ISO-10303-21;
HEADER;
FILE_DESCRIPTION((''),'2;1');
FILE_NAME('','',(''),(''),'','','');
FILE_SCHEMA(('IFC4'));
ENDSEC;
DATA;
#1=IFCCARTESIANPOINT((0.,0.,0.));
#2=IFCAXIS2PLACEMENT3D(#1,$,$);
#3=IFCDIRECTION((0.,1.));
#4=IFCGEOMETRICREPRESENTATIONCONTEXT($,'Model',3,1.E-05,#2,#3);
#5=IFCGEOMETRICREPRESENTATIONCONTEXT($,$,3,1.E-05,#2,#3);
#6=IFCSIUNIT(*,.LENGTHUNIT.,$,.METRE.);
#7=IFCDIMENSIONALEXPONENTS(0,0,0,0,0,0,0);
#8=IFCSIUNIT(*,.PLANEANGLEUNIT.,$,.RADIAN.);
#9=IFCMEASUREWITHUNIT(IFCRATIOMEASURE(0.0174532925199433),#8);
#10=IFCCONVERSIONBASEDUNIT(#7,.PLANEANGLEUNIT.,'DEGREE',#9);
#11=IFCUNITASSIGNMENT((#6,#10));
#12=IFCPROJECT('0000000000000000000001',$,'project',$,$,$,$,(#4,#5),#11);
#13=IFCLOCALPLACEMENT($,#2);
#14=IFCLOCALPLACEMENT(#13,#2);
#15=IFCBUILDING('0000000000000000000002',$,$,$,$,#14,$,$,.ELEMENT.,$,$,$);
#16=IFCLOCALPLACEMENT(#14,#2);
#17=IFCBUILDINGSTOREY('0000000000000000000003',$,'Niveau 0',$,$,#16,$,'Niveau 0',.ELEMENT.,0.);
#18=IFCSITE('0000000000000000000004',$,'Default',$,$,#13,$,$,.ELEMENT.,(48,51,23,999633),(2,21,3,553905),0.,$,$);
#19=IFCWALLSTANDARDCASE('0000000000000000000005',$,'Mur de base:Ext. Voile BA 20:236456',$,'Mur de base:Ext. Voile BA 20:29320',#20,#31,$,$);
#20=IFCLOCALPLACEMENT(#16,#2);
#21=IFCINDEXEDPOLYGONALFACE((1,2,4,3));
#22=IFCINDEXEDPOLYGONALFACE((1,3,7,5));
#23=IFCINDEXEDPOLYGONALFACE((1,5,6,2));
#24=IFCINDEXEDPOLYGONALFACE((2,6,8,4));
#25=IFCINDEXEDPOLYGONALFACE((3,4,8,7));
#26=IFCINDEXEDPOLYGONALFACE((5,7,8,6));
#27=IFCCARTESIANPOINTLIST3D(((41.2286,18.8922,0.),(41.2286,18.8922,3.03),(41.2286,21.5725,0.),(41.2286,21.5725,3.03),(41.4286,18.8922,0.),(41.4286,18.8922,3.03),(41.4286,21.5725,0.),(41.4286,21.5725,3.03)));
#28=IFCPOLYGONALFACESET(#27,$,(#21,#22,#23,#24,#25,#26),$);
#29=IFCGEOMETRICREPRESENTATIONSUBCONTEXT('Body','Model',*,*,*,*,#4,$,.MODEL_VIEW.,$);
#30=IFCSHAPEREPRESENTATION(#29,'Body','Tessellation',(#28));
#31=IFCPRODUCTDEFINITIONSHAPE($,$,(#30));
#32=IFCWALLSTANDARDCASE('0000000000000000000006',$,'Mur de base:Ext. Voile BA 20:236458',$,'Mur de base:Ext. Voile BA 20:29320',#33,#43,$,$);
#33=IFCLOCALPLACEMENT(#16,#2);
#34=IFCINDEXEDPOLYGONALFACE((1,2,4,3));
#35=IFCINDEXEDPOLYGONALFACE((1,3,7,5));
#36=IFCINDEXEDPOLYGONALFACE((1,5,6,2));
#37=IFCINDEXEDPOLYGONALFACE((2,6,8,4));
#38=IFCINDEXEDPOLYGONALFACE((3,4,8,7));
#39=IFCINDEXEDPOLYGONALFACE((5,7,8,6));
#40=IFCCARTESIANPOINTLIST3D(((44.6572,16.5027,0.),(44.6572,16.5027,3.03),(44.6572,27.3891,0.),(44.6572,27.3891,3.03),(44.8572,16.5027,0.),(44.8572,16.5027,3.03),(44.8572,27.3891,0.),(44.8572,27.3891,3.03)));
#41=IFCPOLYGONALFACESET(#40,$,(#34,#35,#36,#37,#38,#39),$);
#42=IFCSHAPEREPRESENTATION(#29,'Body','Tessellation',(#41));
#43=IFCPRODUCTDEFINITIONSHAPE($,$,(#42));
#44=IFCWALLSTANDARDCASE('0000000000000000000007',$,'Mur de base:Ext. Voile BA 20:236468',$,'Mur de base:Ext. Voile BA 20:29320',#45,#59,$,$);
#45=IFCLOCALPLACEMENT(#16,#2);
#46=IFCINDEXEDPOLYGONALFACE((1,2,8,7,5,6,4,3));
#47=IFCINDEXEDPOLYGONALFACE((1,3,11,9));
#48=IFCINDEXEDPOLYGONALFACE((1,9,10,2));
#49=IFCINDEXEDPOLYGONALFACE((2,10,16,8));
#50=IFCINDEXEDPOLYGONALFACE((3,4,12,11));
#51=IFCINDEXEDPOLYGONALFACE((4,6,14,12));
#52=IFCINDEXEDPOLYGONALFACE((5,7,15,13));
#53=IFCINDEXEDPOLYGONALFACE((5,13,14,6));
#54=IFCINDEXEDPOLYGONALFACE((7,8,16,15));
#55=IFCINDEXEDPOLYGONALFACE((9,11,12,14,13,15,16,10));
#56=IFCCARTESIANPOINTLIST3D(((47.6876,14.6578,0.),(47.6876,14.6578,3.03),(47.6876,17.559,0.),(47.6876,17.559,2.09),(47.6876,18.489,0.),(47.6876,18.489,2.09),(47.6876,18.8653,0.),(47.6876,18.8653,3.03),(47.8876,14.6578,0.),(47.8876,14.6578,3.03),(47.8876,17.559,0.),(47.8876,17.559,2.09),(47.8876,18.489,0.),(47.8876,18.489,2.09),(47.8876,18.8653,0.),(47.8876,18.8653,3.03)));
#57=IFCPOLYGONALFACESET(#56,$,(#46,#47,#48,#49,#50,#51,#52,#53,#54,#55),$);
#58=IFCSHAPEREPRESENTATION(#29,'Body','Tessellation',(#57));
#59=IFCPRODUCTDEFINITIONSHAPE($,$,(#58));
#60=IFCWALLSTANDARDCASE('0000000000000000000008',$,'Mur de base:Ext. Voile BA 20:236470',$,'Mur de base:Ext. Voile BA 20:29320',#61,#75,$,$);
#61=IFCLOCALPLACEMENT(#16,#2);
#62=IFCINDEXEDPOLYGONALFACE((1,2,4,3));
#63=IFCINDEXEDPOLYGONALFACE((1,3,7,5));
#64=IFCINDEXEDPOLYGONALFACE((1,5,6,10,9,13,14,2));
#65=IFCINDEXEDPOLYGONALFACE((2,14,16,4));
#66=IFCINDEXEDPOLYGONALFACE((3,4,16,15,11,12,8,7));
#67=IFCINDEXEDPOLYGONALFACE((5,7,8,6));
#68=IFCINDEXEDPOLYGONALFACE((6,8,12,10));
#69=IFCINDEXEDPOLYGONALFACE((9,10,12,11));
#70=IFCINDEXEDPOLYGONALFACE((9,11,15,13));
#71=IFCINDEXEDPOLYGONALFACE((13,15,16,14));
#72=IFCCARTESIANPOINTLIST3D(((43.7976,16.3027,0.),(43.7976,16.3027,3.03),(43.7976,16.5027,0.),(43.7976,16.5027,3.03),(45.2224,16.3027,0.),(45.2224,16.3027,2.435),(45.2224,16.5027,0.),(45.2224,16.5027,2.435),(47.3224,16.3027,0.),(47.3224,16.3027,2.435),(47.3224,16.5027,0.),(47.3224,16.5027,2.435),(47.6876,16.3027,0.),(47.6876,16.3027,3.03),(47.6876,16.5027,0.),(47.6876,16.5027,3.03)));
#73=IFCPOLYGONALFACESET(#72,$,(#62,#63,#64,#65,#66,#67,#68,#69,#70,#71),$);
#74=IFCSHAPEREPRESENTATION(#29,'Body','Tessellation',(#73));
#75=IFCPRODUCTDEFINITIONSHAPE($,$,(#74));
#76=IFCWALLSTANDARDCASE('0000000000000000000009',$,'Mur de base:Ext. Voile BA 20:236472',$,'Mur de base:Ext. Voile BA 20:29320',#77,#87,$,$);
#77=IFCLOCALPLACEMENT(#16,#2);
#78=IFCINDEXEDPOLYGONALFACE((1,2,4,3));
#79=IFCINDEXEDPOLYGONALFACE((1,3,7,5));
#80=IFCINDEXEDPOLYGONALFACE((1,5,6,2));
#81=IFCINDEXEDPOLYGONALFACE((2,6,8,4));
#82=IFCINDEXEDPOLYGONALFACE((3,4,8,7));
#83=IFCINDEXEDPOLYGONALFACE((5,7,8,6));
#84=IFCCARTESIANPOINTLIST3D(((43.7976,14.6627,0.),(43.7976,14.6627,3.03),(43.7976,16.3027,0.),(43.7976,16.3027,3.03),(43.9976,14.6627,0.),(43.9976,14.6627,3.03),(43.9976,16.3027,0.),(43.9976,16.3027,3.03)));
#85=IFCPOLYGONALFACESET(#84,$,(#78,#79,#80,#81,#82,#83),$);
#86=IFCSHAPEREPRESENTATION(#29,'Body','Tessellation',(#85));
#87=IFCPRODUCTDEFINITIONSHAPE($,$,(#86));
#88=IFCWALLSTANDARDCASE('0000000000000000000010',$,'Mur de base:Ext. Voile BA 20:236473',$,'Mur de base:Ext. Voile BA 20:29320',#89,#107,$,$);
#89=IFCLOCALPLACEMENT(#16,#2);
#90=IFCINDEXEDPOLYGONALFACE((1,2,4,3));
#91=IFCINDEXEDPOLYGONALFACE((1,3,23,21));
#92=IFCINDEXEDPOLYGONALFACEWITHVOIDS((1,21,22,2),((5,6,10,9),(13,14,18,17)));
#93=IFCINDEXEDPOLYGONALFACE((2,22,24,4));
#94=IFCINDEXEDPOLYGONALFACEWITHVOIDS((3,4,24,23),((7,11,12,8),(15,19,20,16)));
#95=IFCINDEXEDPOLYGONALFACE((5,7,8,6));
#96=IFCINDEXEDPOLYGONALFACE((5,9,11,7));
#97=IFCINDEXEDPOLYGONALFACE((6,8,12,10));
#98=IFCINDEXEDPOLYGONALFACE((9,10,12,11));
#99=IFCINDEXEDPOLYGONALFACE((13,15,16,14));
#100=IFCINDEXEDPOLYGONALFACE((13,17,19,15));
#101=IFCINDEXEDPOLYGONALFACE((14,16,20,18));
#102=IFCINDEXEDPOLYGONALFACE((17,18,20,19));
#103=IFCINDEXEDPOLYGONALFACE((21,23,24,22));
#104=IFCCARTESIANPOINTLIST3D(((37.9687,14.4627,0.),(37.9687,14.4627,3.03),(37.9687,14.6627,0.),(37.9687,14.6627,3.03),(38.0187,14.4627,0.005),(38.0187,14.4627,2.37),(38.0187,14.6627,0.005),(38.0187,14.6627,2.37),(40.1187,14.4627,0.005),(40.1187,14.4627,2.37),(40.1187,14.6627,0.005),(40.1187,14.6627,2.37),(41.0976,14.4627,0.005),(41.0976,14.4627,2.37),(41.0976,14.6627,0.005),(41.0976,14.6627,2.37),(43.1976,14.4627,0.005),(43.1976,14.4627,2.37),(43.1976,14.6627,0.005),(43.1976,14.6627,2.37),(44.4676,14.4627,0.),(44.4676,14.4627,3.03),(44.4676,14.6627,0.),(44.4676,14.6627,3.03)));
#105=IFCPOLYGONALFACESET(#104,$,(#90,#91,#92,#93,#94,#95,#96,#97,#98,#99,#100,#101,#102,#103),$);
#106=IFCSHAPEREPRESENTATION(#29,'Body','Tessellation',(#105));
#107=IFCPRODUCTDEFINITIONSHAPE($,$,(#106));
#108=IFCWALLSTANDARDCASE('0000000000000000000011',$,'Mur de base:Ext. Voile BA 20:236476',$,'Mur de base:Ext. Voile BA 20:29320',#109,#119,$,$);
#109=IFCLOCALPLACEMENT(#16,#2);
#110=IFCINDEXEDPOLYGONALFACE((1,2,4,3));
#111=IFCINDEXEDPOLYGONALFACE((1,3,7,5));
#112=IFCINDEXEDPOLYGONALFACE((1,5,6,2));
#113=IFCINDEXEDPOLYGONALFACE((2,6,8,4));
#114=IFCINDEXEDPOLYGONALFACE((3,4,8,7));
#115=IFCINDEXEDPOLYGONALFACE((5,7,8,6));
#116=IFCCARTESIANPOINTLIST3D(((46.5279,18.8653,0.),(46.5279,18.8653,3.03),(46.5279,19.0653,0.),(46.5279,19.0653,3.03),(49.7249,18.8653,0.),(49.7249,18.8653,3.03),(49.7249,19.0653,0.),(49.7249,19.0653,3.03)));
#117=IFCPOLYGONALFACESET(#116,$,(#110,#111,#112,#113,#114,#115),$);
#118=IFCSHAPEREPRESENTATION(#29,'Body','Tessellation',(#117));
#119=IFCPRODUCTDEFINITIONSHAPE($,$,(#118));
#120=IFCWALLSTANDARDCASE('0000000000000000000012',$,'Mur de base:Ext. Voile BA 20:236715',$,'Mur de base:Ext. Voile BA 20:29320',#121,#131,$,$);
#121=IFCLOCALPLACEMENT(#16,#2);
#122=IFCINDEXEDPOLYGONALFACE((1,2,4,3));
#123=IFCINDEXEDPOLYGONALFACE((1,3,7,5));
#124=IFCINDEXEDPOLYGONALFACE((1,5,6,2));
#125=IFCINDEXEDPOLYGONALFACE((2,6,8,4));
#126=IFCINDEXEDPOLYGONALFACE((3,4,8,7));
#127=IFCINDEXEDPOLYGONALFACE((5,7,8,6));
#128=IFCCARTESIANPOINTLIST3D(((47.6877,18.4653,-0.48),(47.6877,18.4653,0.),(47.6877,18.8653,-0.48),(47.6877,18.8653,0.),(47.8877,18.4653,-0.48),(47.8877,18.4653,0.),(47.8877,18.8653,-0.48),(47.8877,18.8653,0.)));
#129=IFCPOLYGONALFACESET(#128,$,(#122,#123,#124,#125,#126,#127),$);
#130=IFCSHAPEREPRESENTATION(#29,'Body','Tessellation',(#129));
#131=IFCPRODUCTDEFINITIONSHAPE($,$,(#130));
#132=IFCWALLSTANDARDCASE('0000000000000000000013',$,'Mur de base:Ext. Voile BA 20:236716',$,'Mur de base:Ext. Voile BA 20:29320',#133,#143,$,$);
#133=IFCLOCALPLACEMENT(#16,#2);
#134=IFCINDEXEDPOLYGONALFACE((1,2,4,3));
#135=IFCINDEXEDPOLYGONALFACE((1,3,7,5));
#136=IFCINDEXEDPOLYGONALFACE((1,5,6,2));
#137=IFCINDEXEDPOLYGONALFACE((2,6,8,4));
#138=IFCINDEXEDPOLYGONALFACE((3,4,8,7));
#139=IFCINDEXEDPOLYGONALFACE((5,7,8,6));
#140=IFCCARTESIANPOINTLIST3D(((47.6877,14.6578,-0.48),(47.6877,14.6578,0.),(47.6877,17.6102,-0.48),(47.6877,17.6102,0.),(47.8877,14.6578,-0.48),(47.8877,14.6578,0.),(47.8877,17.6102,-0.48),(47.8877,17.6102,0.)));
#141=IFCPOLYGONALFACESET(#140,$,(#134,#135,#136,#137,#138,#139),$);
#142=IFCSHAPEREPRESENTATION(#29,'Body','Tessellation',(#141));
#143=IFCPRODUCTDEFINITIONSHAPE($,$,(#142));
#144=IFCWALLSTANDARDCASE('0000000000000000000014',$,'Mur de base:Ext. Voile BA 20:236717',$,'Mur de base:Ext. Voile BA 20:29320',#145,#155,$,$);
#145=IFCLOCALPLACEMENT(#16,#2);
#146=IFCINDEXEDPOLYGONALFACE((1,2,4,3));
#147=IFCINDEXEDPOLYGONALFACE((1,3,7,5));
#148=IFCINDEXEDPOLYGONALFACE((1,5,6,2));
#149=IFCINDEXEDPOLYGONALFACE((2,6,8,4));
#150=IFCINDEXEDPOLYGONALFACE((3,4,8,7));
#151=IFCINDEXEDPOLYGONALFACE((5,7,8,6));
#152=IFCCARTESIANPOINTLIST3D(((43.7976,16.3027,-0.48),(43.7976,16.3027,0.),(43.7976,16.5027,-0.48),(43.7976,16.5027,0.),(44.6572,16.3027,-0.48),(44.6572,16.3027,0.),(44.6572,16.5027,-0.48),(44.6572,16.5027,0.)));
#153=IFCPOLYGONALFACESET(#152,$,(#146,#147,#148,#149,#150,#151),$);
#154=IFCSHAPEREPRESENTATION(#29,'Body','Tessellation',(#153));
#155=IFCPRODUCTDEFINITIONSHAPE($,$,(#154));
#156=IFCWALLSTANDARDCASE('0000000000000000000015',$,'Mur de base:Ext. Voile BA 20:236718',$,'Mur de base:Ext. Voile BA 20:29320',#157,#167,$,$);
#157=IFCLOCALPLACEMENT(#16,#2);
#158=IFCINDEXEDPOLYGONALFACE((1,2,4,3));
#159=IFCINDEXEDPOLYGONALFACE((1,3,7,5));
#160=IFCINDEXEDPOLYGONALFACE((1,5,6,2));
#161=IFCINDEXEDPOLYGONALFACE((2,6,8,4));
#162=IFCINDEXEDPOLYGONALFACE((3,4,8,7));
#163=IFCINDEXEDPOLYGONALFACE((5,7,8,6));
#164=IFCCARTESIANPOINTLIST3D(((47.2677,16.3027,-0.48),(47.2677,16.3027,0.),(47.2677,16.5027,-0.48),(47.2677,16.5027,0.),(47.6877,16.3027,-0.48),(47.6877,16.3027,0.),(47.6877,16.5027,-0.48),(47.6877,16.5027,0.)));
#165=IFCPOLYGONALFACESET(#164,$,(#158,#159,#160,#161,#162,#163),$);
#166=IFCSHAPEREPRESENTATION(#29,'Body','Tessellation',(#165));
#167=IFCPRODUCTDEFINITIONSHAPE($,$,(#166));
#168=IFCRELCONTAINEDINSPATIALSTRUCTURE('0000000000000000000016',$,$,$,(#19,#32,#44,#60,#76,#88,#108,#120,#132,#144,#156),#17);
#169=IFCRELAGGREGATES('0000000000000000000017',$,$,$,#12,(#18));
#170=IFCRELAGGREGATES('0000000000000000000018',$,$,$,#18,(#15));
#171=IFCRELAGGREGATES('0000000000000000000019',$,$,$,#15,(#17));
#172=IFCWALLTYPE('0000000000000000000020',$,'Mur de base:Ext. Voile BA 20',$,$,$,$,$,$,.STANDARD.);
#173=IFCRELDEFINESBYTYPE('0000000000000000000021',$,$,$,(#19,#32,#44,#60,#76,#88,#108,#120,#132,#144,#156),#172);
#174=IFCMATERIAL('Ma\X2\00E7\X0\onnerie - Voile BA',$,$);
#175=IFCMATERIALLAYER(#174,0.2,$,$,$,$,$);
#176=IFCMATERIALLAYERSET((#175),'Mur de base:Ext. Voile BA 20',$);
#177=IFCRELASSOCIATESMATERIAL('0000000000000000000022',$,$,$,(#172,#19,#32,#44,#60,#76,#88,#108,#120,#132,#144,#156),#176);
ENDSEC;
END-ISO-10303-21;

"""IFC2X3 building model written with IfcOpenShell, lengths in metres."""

from ifc_helpers import new_model, entity, si_unit, converted_unit, direction, frame, frame_2d, origin, origin_2d_with_axis, place, context, subcontext, project, spatial, rectangle, extrude, material, layer, layer_set, layer_usage, type_object, element, save


model = new_model("IFC2X3")

# Units and contexts
model_context = context("Model", 3, precision=1e-05, world=origin(), true_north=direction((0.0, 1.0)))
context_of_model = context(None, 3, precision=1e-05, world=origin(), true_north=direction((0.0, 1.0)))
body_context = subcontext(model_context, "Body", "Model", "MODEL_VIEW")
ifc_project = project(units=[si_unit("LENGTHUNIT", "METRE"), converted_unit("PLANEANGLEUNIT", "DEGREE", entity("IfcRatioMeasure", 0.0174532925199433), si_unit("PLANEANGLEUNIT", "RADIAN"), dimensions=[0, 0, 0, 0, 0, 0, 0])], contexts=[model_context, context_of_model])

# Site, building, storey
site_placement = place(None, origin())
site = spatial("IfcSite", under=ifc_project, at=site_placement, Name="Default", CompositionType="ELEMENT", RefLatitude=(48, 51, 23, 999633), RefLongitude=(2, 21, 3, 553905), RefElevation=0.0)
building_placement = place(site_placement, origin())
building = spatial("IfcBuilding", under=site, at=building_placement, CompositionType="ELEMENT")
storey_placement = place(building_placement, origin())
storey = spatial("IfcBuildingStorey", under=building, at=storey_placement, Name="Niveau 0", LongName="Niveau 0", CompositionType="ELEMENT", Elevation=0.0)

# Walls
ifc_material = material(Name="Maçonnerie - Voile BA")
ifc_layer_1 = layer(ifc_material, 0.2)
ifc_layer_set_1 = layer_set([ifc_layer_1], Name="Mur de base:Ext. Voile BA 20")
ifc_layer_usage_1 = layer_usage(ifc_layer_set_1, "AXIS2", "NEGATIVE", 0.1)
wall_type_1 = type_object("IfcWallType", Name="Mur de base:Ext. Voile BA 20", PredefinedType="STANDARD", material=ifc_layer_set_1)
wall_1_placement = place(storey_placement, frame((41.3286, 18.8922, 0.0), z_axis=(0.0, 0.0, 1.0), x_axis=(0.0, 1.0, 0.0)))
element("IfcWallStandardCase", 1, at=wall_1_placement, inside=storey, type_object=wall_type_1, material=ifc_layer_usage_1, Name="Mur de base:Ext. Voile BA 20:236456", ObjectType="Mur de base:Ext. Voile BA 20:29320", context=body_context, shape_type="SweptSolid", body=[
    extrude(rectangle(XDim=2.6803, YDim=0.2, at=frame_2d((1.3402, 0.0), x_axis=(-1.0, 0.0))), origin(), (0.0, 0.0, 1.0), 3.03),
])
ifc_layer_usage_2 = layer_usage(ifc_layer_set_1, "AXIS2", "NEGATIVE", 0.1)
wall_2_placement = place(storey_placement, frame((44.7572, 16.5027, 0.0), z_axis=(0.0, 0.0, 1.0), x_axis=(0.0, 1.0, 0.0)))
element("IfcWallStandardCase", 2, at=wall_2_placement, inside=storey, type_object=wall_type_1, material=ifc_layer_usage_2, Name="Mur de base:Ext. Voile BA 20:236458", ObjectType="Mur de base:Ext. Voile BA 20:29320", context=body_context, shape_type="SweptSolid", body=[
    extrude(rectangle(XDim=10.8864, YDim=0.2, at=frame_2d((5.4432, 0.0), x_axis=(-1.0, 0.0))), origin(), (0.0, 0.0, 1.0), 3.03),
])

# Walls, openings
ifc_layer_usage_3 = layer_usage(ifc_layer_set_1, "AXIS2", "NEGATIVE", 0.1)
wall_3_placement = place(storey_placement, frame((47.7876, 14.6578, 0.0), z_axis=(0.0, 0.0, 1.0), x_axis=(0.0, 1.0, 0.0)))
wall_3 = element("IfcWallStandardCase", 3, at=wall_3_placement, inside=storey, type_object=wall_type_1, material=ifc_layer_usage_3, Name="Mur de base:Ext. Voile BA 20:236468", ObjectType="Mur de base:Ext. Voile BA 20:29320", context=body_context, shape_type="SweptSolid", body=[
    extrude(rectangle(XDim=4.2075, YDim=0.2, at=frame_2d((2.1037, 0.0), x_axis=(-1.0, 0.0))), origin(), (0.0, 0.0, 1.0), 3.03),
])
opening_1_placement = place(wall_3_placement, origin())
element("IfcOpeningElement", 4, at=opening_1_placement, cuts=wall_3, ObjectType="Opening", context=body_context, shape_type="SweptSolid", body=[
    extrude(rectangle(XDim=2.09, YDim=0.93, at=origin_2d_with_axis()), frame((3.3661, -0.1, 1.045), z_axis=(0.0, 1.0, 0.0), x_axis=(0.0, 0.0, -1.0)), (0.0, 0.0, 1.0), 0.2),
])
ifc_layer_usage_4 = layer_usage(ifc_layer_set_1, "AXIS2", "NEGATIVE", 0.1)
wall_4_placement = place(storey_placement, frame((47.6876, 16.4027, 0.0), z_axis=(0.0, 0.0, 1.0), x_axis=(-1.0, 0.0, 0.0)))
wall_4 = element("IfcWallStandardCase", 5, at=wall_4_placement, inside=storey, type_object=wall_type_1, material=ifc_layer_usage_4, Name="Mur de base:Ext. Voile BA 20:236470", ObjectType="Mur de base:Ext. Voile BA 20:29320", context=body_context, shape_type="SweptSolid", body=[
    extrude(rectangle(XDim=3.89, YDim=0.2, at=frame_2d((1.945, 0.0), x_axis=(-1.0, 0.0))), origin(), (0.0, 0.0, 1.0), 3.03),
])
opening_2_placement = place(wall_4_placement, origin())
element("IfcOpeningElement", 6, at=opening_2_placement, cuts=wall_4, ObjectType="Opening", context=body_context, shape_type="SweptSolid", body=[
    extrude(rectangle(XDim=2.465, YDim=2.1, at=frame_2d((0.0, 0.0), x_axis=(1.0, 0.0))), frame((1.4152, -0.1, 1.2025), z_axis=(0.0, 1.0, 0.0), x_axis=(0.0, 0.0, -1.0)), (0.0, 0.0, 1.0), 0.2),
])

# Wall
ifc_layer_usage_5 = layer_usage(ifc_layer_set_1, "AXIS2", "NEGATIVE", 0.1)
wall_5_placement = place(storey_placement, frame((43.8976, 16.3027, 0.0), z_axis=(0.0, 0.0, 1.0), x_axis=(0.0, -1.0, 0.0)))
element("IfcWallStandardCase", 7, at=wall_5_placement, inside=storey, type_object=wall_type_1, material=ifc_layer_usage_5, Name="Mur de base:Ext. Voile BA 20:236472", ObjectType="Mur de base:Ext. Voile BA 20:29320", context=body_context, shape_type="SweptSolid", body=[
    extrude(rectangle(XDim=1.64, YDim=0.2, at=frame_2d((0.82, 0.0), x_axis=(-1.0, 0.0))), origin(), (0.0, 0.0, 1.0), 3.03),
])

# Wall, openings
ifc_layer_usage_6 = layer_usage(ifc_layer_set_1, "AXIS2", "NEGATIVE", 0.1)
wall_6_placement = place(storey_placement, frame((44.4676, 14.5627, 0.0), z_axis=(0.0, 0.0, 1.0), x_axis=(-1.0, 0.0, 0.0)))
wall_6 = element("IfcWallStandardCase", 8, at=wall_6_placement, inside=storey, type_object=wall_type_1, material=ifc_layer_usage_6, Name="Mur de base:Ext. Voile BA 20:236473", ObjectType="Mur de base:Ext. Voile BA 20:29320", context=body_context, shape_type="SweptSolid", body=[
    extrude(rectangle(XDim=6.4988, YDim=0.2, at=frame_2d((3.2494, 0.0), x_axis=(-1.0, 0.0))), origin(), (0.0, 0.0, 1.0), 3.03),
])
opening_3_placement = place(wall_6_placement, origin())
element("IfcOpeningElement", 9, at=opening_3_placement, cuts=wall_6, ObjectType="Opening", context=body_context, shape_type="SweptSolid", body=[
    extrude(rectangle(XDim=2.365, YDim=2.1, at=frame_2d((0.0, 0.0), x_axis=(1.0, 0.0))), frame((5.3988, -0.1, 1.1875), z_axis=(0.0, 1.0, 0.0), x_axis=(0.0, 0.0, -1.0)), (0.0, 0.0, 1.0), 0.2),
])
opening_4_placement = place(wall_6_placement, origin())
element("IfcOpeningElement", 10, at=opening_4_placement, cuts=wall_6, ObjectType="Opening", context=body_context, shape_type="SweptSolid", body=[
    extrude(rectangle(XDim=2.365, YDim=2.1, at=origin_2d_with_axis()), frame((2.32, -0.1, 1.1875), z_axis=(0.0, 1.0, 0.0), x_axis=(0.0, 0.0, -1.0)), (0.0, 0.0, 1.0), 0.2),
])

# Walls
ifc_layer_usage_7 = layer_usage(ifc_layer_set_1, "AXIS2", "NEGATIVE", 0.1)
wall_7_placement = place(storey_placement, frame((46.5279, 18.9653, 0.0)))
element("IfcWallStandardCase", 11, at=wall_7_placement, inside=storey, type_object=wall_type_1, material=ifc_layer_usage_7, Name="Mur de base:Ext. Voile BA 20:236476", ObjectType="Mur de base:Ext. Voile BA 20:29320", context=body_context, shape_type="SweptSolid", body=[
    extrude(rectangle(XDim=3.197, YDim=0.2, at=frame_2d((1.5985, 0.0), x_axis=(-1.0, 0.0))), origin(), (0.0, 0.0, 1.0), 3.03),
])
ifc_layer_usage_8 = layer_usage(ifc_layer_set_1, "AXIS2", "NEGATIVE", 0.1)
wall_8_placement = place(storey_placement, frame((47.7877, 18.8653, -0.48), z_axis=(0.0, 0.0, 1.0), x_axis=(0.0, -1.0, 0.0)))
element("IfcWallStandardCase", 12, at=wall_8_placement, inside=storey, type_object=wall_type_1, material=ifc_layer_usage_8, Name="Mur de base:Ext. Voile BA 20:236715", ObjectType="Mur de base:Ext. Voile BA 20:29320", context=body_context, shape_type="SweptSolid", body=[
    extrude(rectangle(XDim=0.4, YDim=0.2, at=frame_2d((0.2, 0.0), x_axis=(-1.0, 0.0))), origin(), (0.0, 0.0, 1.0), 0.48),
])
ifc_layer_usage_9 = layer_usage(ifc_layer_set_1, "AXIS2", "NEGATIVE", 0.1)
wall_9_placement = place(storey_placement, frame((47.7877, 17.6102, -0.48), z_axis=(0.0, 0.0, 1.0), x_axis=(0.0, -1.0, 0.0)))
element("IfcWallStandardCase", 13, at=wall_9_placement, inside=storey, type_object=wall_type_1, material=ifc_layer_usage_9, Name="Mur de base:Ext. Voile BA 20:236716", ObjectType="Mur de base:Ext. Voile BA 20:29320", context=body_context, shape_type="SweptSolid", body=[
    extrude(rectangle(XDim=2.9523, YDim=0.2, at=frame_2d((1.4762, 0.0), x_axis=(-1.0, 0.0))), origin(), (0.0, 0.0, 1.0), 0.48),
])
ifc_layer_usage_10 = layer_usage(ifc_layer_set_1, "AXIS2", "NEGATIVE", 0.1)
wall_10_placement = place(storey_placement, frame((43.7976, 16.4027, -0.48)))
element("IfcWallStandardCase", 14, at=wall_10_placement, inside=storey, type_object=wall_type_1, material=ifc_layer_usage_10, Name="Mur de base:Ext. Voile BA 20:236717", ObjectType="Mur de base:Ext. Voile BA 20:29320", context=body_context, shape_type="SweptSolid", body=[
    extrude(rectangle(XDim=0.8597, YDim=0.2, at=frame_2d((0.4298, 0.0), x_axis=(-1.0, 0.0))), origin(), (0.0, 0.0, 1.0), 0.48),
])
ifc_layer_usage_11 = layer_usage(ifc_layer_set_1, "AXIS2", "NEGATIVE", 0.1)
wall_11_placement = place(storey_placement, frame((47.6877, 16.4027, -0.48), z_axis=(0.0, 0.0, 1.0), x_axis=(-1.0, 0.0, 0.0)))
element("IfcWallStandardCase", 15, at=wall_11_placement, inside=storey, type_object=wall_type_1, material=ifc_layer_usage_11, Name="Mur de base:Ext. Voile BA 20:236718", ObjectType="Mur de base:Ext. Voile BA 20:29320", context=body_context, shape_type="SweptSolid", body=[
    extrude(rectangle(XDim=0.42, YDim=0.2, at=frame_2d((0.21, 0.0), x_axis=(-1.0, 0.0))), origin(), (0.0, 0.0, 1.0), 0.48),
])

save(model, "model.ifc")
